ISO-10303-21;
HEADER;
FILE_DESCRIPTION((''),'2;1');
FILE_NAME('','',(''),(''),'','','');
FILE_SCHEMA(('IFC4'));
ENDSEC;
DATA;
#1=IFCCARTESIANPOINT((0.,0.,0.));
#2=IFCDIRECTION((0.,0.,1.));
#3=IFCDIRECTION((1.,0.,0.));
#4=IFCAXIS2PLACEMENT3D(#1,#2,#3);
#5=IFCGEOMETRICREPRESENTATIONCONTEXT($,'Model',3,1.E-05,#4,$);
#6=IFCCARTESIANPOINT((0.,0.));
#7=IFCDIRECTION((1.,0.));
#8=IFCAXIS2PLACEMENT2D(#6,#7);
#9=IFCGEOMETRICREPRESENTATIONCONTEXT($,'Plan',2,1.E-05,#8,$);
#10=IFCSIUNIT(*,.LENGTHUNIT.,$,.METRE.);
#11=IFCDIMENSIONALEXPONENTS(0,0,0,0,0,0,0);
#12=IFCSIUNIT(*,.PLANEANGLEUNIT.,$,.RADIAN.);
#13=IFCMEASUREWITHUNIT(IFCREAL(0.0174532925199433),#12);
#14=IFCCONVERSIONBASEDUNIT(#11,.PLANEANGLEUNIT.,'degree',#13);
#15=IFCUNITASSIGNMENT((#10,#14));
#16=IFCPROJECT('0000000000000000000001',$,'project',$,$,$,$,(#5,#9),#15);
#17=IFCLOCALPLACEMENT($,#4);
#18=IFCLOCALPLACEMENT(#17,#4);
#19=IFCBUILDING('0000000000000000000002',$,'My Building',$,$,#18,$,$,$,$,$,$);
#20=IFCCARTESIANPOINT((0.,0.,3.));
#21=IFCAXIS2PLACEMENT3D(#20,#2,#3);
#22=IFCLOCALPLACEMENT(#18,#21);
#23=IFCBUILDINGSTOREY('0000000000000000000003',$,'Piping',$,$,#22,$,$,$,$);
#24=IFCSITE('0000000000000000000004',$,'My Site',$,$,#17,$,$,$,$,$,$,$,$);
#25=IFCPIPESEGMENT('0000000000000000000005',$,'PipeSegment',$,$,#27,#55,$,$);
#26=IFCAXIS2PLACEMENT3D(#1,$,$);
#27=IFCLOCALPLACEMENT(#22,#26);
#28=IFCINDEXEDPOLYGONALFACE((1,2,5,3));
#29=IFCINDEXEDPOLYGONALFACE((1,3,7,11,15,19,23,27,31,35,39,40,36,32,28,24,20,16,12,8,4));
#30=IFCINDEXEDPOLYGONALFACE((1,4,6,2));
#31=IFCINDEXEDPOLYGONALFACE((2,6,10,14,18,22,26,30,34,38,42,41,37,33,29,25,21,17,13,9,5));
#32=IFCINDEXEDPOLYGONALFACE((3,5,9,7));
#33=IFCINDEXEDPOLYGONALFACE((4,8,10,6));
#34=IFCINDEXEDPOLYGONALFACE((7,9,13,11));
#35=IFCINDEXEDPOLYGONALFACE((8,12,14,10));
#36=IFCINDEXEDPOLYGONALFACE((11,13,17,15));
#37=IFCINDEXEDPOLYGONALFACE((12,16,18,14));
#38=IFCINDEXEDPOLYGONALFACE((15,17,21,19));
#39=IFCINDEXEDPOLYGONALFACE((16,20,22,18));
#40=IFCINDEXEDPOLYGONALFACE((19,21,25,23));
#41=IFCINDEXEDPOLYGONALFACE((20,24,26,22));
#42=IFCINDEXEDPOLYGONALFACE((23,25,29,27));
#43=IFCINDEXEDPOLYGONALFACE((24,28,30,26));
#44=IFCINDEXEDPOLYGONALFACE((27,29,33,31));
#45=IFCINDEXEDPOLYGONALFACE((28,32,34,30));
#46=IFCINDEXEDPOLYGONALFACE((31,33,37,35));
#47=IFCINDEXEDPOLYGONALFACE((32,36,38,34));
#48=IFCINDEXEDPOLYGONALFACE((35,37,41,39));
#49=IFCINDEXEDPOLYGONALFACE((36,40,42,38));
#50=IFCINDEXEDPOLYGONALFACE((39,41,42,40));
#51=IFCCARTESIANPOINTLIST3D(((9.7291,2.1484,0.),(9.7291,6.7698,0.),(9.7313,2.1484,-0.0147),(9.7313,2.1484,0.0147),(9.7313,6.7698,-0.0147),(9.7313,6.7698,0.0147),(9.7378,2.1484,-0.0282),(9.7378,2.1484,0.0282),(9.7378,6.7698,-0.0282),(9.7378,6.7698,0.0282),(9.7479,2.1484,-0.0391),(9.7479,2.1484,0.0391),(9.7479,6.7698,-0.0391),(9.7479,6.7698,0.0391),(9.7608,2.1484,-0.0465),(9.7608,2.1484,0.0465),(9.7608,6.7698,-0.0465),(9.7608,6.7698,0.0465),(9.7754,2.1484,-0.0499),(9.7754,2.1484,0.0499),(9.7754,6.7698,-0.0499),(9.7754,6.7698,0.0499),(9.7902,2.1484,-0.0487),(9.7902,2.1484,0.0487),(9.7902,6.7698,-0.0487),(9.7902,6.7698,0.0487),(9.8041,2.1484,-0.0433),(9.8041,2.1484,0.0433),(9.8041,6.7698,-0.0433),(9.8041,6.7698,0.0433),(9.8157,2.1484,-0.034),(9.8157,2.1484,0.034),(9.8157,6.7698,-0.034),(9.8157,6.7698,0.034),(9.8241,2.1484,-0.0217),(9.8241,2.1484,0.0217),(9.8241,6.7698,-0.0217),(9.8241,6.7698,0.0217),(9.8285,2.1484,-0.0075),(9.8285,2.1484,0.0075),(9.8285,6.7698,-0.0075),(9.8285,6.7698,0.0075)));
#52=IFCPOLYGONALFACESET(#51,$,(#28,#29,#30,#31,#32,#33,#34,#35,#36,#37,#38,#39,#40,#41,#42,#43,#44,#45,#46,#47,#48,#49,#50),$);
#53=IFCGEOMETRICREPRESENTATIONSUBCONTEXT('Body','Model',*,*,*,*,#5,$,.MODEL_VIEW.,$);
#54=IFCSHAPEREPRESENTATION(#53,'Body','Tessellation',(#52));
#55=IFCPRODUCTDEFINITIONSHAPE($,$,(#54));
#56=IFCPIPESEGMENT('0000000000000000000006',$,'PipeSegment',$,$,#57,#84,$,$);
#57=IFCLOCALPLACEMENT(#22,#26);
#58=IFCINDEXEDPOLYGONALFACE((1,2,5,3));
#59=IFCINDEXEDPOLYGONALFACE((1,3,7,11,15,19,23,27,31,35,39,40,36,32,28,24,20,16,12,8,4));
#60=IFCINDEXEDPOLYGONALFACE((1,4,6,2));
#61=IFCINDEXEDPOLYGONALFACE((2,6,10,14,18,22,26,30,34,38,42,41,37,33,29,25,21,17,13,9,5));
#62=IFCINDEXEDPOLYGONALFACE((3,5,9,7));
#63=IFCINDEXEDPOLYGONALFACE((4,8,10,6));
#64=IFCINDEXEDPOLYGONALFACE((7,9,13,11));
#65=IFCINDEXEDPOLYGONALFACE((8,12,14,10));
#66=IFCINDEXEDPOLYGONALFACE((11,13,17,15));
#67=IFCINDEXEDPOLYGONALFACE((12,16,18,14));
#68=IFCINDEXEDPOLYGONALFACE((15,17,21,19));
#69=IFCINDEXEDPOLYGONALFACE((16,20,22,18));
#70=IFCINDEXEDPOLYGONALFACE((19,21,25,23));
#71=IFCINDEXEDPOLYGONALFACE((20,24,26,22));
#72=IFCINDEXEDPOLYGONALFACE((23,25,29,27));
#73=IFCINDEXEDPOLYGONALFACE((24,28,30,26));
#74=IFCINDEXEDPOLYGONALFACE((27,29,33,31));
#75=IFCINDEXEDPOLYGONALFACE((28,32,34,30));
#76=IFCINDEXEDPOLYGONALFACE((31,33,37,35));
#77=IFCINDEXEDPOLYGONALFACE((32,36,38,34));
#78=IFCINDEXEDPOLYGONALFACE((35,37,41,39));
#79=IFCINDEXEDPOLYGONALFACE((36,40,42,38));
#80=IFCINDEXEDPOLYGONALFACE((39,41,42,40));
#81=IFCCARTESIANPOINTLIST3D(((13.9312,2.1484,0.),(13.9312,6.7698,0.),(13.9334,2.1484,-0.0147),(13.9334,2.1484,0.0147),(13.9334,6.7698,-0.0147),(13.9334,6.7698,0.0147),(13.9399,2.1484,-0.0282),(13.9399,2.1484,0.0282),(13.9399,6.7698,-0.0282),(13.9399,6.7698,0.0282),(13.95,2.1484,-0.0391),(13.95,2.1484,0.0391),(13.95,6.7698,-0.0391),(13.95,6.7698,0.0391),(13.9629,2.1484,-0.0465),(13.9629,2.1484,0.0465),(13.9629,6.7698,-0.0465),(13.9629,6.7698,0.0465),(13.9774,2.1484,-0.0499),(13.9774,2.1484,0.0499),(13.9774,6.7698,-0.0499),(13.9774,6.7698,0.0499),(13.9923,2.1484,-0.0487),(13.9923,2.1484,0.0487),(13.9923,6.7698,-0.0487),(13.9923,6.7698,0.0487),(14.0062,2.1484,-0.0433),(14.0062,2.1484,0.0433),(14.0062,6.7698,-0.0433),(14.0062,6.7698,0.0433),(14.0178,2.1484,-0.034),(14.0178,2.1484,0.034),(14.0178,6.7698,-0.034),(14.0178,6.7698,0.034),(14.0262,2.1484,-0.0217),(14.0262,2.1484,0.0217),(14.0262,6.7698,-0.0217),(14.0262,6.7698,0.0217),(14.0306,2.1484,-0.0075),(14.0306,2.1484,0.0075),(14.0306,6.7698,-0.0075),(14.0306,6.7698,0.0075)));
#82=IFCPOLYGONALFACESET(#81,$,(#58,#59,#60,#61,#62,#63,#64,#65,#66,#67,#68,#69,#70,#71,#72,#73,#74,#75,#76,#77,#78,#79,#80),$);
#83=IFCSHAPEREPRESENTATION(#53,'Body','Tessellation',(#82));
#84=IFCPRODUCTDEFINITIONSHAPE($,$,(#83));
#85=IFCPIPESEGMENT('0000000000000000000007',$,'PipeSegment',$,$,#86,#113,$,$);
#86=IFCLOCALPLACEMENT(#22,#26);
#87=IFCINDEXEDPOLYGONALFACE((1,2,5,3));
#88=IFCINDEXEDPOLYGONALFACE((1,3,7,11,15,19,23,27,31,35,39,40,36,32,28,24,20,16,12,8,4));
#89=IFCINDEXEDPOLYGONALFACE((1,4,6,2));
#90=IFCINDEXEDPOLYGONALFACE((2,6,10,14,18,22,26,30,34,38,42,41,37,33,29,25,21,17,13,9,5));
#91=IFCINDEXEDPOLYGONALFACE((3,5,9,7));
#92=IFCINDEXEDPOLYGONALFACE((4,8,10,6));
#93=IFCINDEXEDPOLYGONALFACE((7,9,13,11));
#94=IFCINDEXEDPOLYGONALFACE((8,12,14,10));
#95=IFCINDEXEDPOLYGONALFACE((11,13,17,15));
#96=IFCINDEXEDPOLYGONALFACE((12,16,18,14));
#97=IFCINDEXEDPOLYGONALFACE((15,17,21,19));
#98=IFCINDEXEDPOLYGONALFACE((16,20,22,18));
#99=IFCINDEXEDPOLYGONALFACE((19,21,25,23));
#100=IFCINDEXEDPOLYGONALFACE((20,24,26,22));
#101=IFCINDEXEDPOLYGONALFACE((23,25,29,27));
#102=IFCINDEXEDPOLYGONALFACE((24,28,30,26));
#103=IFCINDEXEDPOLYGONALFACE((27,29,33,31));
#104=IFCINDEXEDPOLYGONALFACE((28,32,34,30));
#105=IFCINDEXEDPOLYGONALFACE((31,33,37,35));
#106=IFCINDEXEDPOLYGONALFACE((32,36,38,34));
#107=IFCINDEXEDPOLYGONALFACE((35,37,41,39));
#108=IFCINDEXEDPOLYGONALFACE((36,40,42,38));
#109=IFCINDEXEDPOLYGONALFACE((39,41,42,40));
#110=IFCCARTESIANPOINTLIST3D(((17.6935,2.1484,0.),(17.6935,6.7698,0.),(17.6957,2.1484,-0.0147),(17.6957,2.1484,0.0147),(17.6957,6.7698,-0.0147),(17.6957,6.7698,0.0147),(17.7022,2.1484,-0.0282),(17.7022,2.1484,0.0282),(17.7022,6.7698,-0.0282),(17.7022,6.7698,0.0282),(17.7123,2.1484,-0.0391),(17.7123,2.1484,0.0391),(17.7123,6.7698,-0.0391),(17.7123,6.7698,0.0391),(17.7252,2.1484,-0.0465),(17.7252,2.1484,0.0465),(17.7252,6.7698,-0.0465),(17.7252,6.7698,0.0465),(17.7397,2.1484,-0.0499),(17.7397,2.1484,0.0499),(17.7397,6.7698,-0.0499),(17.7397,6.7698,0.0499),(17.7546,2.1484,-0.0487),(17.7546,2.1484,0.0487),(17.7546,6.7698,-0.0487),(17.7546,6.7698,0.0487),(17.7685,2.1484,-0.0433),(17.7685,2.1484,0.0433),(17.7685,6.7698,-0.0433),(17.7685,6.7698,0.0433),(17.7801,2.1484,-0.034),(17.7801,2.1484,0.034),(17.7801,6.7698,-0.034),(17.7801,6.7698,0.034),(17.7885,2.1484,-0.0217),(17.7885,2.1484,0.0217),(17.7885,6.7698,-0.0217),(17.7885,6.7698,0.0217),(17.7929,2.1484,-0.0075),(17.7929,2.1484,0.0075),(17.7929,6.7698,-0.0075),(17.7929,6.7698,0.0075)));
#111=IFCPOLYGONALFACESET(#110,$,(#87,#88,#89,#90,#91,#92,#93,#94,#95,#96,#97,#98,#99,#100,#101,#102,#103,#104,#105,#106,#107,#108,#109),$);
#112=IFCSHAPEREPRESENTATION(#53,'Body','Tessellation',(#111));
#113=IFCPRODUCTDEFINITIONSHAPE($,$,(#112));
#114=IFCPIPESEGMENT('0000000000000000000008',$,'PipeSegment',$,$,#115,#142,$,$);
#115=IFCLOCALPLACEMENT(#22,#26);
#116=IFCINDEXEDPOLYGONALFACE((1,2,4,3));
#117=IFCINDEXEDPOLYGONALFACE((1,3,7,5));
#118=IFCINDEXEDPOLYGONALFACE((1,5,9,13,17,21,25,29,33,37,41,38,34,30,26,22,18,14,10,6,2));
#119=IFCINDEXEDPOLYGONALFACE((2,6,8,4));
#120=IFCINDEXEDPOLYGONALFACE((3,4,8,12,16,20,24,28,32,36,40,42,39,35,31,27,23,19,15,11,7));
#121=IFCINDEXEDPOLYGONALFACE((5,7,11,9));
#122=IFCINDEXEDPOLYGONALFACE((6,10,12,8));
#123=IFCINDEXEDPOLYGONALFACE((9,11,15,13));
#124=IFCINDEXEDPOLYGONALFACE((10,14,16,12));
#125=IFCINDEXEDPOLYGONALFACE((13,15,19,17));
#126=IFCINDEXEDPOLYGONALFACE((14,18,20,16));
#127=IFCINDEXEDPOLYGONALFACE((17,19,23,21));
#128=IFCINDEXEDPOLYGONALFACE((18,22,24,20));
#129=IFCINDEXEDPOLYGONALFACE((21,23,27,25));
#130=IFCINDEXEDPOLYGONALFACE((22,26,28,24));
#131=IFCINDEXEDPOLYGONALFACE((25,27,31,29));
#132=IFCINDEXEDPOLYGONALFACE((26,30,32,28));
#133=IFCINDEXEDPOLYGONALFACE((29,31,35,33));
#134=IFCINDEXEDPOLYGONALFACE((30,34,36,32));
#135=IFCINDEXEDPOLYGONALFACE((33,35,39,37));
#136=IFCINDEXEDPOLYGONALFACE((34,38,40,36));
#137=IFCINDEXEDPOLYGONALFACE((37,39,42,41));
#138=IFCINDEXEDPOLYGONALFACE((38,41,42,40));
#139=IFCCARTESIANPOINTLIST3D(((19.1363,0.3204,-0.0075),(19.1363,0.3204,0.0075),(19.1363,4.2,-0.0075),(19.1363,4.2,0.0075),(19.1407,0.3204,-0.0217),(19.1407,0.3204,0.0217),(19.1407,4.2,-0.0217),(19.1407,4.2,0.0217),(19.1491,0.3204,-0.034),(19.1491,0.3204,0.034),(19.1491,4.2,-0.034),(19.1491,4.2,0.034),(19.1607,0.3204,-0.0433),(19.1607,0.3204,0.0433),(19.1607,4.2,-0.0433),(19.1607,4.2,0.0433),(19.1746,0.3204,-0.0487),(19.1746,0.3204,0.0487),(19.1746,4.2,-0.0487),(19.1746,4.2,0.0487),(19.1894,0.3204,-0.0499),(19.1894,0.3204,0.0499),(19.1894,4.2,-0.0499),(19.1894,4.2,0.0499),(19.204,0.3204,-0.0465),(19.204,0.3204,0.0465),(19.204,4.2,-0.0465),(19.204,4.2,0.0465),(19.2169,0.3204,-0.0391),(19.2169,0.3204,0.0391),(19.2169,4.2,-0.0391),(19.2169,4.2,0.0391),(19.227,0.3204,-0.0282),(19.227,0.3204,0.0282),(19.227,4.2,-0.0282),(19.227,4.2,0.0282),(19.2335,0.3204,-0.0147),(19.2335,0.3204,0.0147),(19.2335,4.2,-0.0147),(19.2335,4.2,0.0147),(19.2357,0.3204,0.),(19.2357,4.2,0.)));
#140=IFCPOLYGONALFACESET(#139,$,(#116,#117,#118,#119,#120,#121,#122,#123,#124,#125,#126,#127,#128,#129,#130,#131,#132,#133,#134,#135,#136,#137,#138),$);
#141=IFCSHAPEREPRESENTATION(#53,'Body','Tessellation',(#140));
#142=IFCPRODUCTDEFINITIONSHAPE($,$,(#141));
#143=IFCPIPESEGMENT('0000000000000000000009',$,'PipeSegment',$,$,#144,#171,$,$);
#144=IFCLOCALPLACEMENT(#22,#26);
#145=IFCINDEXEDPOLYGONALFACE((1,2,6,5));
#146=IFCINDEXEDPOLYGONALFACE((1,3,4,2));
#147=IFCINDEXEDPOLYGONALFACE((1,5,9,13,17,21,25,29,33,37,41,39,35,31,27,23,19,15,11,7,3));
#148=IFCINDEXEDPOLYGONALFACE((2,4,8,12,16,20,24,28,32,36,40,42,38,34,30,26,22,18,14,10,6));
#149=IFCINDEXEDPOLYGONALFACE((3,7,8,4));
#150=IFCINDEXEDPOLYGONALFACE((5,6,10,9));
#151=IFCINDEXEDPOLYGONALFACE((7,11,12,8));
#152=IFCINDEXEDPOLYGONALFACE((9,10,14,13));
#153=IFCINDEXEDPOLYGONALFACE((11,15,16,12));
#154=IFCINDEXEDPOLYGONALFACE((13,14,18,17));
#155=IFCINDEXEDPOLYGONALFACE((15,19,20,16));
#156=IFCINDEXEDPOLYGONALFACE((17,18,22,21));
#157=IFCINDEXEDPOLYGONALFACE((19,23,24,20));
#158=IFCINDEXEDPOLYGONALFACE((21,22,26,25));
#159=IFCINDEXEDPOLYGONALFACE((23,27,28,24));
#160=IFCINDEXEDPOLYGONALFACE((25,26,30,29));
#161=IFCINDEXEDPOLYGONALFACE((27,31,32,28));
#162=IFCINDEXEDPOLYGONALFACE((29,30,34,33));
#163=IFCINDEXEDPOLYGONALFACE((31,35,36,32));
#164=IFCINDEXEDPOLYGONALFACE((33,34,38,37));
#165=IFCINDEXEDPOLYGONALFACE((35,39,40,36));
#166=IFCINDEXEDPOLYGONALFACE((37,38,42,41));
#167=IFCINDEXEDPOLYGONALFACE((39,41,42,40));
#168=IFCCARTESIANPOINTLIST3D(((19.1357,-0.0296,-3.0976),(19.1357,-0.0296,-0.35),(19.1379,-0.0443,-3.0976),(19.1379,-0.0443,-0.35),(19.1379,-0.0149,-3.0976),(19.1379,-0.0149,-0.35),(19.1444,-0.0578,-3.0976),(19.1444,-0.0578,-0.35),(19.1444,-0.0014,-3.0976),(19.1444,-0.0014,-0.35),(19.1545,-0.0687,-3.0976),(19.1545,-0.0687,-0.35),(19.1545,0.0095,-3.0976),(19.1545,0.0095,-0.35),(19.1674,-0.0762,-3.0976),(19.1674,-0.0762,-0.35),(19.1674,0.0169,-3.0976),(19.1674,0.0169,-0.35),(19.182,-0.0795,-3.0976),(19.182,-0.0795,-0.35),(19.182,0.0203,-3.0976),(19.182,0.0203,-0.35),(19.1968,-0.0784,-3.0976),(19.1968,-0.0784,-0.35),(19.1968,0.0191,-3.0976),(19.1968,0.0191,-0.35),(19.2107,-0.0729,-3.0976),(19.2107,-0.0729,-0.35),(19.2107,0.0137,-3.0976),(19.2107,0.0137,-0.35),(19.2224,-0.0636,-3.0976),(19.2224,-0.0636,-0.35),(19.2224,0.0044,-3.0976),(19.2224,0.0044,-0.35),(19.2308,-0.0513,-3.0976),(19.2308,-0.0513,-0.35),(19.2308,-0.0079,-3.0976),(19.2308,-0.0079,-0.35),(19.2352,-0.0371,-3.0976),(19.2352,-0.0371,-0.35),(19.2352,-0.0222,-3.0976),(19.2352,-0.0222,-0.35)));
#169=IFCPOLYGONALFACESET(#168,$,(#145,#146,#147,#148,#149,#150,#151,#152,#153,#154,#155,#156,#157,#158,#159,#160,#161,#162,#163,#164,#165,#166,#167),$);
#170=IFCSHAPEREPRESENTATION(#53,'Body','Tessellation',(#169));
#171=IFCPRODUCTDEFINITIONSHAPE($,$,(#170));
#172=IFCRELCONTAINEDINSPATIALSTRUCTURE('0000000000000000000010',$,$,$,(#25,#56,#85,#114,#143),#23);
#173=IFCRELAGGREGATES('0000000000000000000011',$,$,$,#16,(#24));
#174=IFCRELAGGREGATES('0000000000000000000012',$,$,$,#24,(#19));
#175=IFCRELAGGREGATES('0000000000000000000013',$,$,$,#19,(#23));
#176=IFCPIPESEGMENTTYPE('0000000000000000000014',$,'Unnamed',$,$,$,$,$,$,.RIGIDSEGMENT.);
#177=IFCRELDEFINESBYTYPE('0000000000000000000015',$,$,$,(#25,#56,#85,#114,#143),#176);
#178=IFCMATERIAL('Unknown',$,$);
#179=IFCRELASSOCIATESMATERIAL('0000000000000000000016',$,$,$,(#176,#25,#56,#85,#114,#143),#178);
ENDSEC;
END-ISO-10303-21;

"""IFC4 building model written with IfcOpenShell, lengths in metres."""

from ifc_helpers import new_model, entity, si_unit, converted_unit, frame, origin_with_axes, origin_2d_with_axis, place, context, subcontext, project, spatial, circle, extrude, material, material_profile, profile_set, profile_usage, type_object, element, save


model = new_model("IFC4")

# Units and contexts
model_context = context("Model", 3, precision=1e-05, world=origin_with_axes())
plan_context = context("Plan", 2, precision=1e-05, world=origin_2d_with_axis())
body_context = subcontext(model_context, "Body", "Model", "MODEL_VIEW")
ifc_project = project(units=[si_unit("LENGTHUNIT", "METRE"), converted_unit("PLANEANGLEUNIT", "degree", entity("IfcReal", 0.0174532925199433), si_unit("PLANEANGLEUNIT", "RADIAN"), dimensions=[0, 0, 0, 0, 0, 0, 0])], contexts=[model_context, plan_context])

# Site, building, storey
site_placement = place(None, origin_with_axes())
site = spatial("IfcSite", under=ifc_project, at=site_placement, Name="My Site")
building_placement = place(site_placement, origin_with_axes())
building = spatial("IfcBuilding", under=site, at=building_placement, Name="My Building")
storey_placement = place(building_placement, frame((0.0, 0.0, 3.0), z_axis=(0.0, 0.0, 1.0), x_axis=(1.0, 0.0, 0.0)))
storey = spatial("IfcBuildingStorey", under=building, at=storey_placement, Name="Piping")

# Shared definitions
ifc_material = material(Name="Unknown")
ifc_material_profile = material_profile(ifc_material, circle(Radius=0.05))
ifc_profile_set = profile_set([ifc_material_profile])
pipe_segment_type = type_object("IfcPipeSegmentType", Name="Unnamed", PredefinedType="RIGIDSEGMENT", material=ifc_profile_set)

# Pipe segments
ifc_profile_usage_1 = profile_usage(ifc_profile_set, cardinal=5)
pipe_segment_1_placement = place(storey_placement, frame((9.7791, 2.1484, 0.0), z_axis=(0.0, 1.0, 0.0), x_axis=(-1.0, 0.0, 0.0)))
element("IfcPipeSegment", 1, at=pipe_segment_1_placement, inside=storey, type_object=pipe_segment_type, material=ifc_profile_usage_1, Name="PipeSegment", context=body_context, shape_type="SweptSolid", body=[
    extrude(circle(Radius=0.05), origin_with_axes(), (0.0, 0.0, 1.0), 4.6214),
])
ifc_profile_usage_2 = profile_usage(ifc_profile_set, cardinal=5)
pipe_segment_2_placement = place(storey_placement, frame((13.9812, 2.1484, 0.0), z_axis=(0.0, 1.0, 0.0), x_axis=(-1.0, 0.0, 0.0)))
element("IfcPipeSegment", 2, at=pipe_segment_2_placement, inside=storey, type_object=pipe_segment_type, material=ifc_profile_usage_2, Name="PipeSegment", context=body_context, shape_type="SweptSolid", body=[
    extrude(circle(Radius=0.05), origin_with_axes(), (0.0, 0.0, 1.0), 4.6214),
])
ifc_profile_usage_3 = profile_usage(ifc_profile_set, cardinal=5)
pipe_segment_3_placement = place(storey_placement, frame((17.7435, 2.1484, 0.0), z_axis=(0.0, 1.0, 0.0), x_axis=(-1.0, 0.0, 0.0)))
element("IfcPipeSegment", 3, at=pipe_segment_3_placement, inside=storey, type_object=pipe_segment_type, material=ifc_profile_usage_3, Name="PipeSegment", context=body_context, shape_type="SweptSolid", body=[
    extrude(circle(Radius=0.05), origin_with_axes(), (0.0, 0.0, 1.0), 4.6214),
])
ifc_profile_usage_4 = profile_usage(ifc_profile_set, cardinal=5)
pipe_segment_4_placement = place(storey_placement, frame((19.1857, 4.2, 0.0), z_axis=(0.0, -1.0, 0.0), x_axis=(1.0, 0.0, 0.0)))
element("IfcPipeSegment", 4, at=pipe_segment_4_placement, inside=storey, type_object=pipe_segment_type, material=ifc_profile_usage_4, Name="PipeSegment", context=body_context, shape_type="SweptSolid", body=[
    extrude(circle(Radius=0.05), origin_with_axes(), (0.0, 0.0, 1.0), 3.8796),
])
ifc_profile_usage_5 = profile_usage(ifc_profile_set, cardinal=5)
pipe_segment_5_placement = place(storey_placement, frame((19.1857, -0.0296, -0.35), z_axis=(0.0, 0.0, -1.0), x_axis=(-1.0, 0.0, 0.0)))
element("IfcPipeSegment", 5, at=pipe_segment_5_placement, inside=storey, type_object=pipe_segment_type, material=ifc_profile_usage_5, Name="PipeSegment", context=body_context, shape_type="SweptSolid", body=[
    extrude(circle(Radius=0.05), origin_with_axes(), (0.0, 0.0, 1.0), 2.7476),
])

save(model, "model.ifc")
